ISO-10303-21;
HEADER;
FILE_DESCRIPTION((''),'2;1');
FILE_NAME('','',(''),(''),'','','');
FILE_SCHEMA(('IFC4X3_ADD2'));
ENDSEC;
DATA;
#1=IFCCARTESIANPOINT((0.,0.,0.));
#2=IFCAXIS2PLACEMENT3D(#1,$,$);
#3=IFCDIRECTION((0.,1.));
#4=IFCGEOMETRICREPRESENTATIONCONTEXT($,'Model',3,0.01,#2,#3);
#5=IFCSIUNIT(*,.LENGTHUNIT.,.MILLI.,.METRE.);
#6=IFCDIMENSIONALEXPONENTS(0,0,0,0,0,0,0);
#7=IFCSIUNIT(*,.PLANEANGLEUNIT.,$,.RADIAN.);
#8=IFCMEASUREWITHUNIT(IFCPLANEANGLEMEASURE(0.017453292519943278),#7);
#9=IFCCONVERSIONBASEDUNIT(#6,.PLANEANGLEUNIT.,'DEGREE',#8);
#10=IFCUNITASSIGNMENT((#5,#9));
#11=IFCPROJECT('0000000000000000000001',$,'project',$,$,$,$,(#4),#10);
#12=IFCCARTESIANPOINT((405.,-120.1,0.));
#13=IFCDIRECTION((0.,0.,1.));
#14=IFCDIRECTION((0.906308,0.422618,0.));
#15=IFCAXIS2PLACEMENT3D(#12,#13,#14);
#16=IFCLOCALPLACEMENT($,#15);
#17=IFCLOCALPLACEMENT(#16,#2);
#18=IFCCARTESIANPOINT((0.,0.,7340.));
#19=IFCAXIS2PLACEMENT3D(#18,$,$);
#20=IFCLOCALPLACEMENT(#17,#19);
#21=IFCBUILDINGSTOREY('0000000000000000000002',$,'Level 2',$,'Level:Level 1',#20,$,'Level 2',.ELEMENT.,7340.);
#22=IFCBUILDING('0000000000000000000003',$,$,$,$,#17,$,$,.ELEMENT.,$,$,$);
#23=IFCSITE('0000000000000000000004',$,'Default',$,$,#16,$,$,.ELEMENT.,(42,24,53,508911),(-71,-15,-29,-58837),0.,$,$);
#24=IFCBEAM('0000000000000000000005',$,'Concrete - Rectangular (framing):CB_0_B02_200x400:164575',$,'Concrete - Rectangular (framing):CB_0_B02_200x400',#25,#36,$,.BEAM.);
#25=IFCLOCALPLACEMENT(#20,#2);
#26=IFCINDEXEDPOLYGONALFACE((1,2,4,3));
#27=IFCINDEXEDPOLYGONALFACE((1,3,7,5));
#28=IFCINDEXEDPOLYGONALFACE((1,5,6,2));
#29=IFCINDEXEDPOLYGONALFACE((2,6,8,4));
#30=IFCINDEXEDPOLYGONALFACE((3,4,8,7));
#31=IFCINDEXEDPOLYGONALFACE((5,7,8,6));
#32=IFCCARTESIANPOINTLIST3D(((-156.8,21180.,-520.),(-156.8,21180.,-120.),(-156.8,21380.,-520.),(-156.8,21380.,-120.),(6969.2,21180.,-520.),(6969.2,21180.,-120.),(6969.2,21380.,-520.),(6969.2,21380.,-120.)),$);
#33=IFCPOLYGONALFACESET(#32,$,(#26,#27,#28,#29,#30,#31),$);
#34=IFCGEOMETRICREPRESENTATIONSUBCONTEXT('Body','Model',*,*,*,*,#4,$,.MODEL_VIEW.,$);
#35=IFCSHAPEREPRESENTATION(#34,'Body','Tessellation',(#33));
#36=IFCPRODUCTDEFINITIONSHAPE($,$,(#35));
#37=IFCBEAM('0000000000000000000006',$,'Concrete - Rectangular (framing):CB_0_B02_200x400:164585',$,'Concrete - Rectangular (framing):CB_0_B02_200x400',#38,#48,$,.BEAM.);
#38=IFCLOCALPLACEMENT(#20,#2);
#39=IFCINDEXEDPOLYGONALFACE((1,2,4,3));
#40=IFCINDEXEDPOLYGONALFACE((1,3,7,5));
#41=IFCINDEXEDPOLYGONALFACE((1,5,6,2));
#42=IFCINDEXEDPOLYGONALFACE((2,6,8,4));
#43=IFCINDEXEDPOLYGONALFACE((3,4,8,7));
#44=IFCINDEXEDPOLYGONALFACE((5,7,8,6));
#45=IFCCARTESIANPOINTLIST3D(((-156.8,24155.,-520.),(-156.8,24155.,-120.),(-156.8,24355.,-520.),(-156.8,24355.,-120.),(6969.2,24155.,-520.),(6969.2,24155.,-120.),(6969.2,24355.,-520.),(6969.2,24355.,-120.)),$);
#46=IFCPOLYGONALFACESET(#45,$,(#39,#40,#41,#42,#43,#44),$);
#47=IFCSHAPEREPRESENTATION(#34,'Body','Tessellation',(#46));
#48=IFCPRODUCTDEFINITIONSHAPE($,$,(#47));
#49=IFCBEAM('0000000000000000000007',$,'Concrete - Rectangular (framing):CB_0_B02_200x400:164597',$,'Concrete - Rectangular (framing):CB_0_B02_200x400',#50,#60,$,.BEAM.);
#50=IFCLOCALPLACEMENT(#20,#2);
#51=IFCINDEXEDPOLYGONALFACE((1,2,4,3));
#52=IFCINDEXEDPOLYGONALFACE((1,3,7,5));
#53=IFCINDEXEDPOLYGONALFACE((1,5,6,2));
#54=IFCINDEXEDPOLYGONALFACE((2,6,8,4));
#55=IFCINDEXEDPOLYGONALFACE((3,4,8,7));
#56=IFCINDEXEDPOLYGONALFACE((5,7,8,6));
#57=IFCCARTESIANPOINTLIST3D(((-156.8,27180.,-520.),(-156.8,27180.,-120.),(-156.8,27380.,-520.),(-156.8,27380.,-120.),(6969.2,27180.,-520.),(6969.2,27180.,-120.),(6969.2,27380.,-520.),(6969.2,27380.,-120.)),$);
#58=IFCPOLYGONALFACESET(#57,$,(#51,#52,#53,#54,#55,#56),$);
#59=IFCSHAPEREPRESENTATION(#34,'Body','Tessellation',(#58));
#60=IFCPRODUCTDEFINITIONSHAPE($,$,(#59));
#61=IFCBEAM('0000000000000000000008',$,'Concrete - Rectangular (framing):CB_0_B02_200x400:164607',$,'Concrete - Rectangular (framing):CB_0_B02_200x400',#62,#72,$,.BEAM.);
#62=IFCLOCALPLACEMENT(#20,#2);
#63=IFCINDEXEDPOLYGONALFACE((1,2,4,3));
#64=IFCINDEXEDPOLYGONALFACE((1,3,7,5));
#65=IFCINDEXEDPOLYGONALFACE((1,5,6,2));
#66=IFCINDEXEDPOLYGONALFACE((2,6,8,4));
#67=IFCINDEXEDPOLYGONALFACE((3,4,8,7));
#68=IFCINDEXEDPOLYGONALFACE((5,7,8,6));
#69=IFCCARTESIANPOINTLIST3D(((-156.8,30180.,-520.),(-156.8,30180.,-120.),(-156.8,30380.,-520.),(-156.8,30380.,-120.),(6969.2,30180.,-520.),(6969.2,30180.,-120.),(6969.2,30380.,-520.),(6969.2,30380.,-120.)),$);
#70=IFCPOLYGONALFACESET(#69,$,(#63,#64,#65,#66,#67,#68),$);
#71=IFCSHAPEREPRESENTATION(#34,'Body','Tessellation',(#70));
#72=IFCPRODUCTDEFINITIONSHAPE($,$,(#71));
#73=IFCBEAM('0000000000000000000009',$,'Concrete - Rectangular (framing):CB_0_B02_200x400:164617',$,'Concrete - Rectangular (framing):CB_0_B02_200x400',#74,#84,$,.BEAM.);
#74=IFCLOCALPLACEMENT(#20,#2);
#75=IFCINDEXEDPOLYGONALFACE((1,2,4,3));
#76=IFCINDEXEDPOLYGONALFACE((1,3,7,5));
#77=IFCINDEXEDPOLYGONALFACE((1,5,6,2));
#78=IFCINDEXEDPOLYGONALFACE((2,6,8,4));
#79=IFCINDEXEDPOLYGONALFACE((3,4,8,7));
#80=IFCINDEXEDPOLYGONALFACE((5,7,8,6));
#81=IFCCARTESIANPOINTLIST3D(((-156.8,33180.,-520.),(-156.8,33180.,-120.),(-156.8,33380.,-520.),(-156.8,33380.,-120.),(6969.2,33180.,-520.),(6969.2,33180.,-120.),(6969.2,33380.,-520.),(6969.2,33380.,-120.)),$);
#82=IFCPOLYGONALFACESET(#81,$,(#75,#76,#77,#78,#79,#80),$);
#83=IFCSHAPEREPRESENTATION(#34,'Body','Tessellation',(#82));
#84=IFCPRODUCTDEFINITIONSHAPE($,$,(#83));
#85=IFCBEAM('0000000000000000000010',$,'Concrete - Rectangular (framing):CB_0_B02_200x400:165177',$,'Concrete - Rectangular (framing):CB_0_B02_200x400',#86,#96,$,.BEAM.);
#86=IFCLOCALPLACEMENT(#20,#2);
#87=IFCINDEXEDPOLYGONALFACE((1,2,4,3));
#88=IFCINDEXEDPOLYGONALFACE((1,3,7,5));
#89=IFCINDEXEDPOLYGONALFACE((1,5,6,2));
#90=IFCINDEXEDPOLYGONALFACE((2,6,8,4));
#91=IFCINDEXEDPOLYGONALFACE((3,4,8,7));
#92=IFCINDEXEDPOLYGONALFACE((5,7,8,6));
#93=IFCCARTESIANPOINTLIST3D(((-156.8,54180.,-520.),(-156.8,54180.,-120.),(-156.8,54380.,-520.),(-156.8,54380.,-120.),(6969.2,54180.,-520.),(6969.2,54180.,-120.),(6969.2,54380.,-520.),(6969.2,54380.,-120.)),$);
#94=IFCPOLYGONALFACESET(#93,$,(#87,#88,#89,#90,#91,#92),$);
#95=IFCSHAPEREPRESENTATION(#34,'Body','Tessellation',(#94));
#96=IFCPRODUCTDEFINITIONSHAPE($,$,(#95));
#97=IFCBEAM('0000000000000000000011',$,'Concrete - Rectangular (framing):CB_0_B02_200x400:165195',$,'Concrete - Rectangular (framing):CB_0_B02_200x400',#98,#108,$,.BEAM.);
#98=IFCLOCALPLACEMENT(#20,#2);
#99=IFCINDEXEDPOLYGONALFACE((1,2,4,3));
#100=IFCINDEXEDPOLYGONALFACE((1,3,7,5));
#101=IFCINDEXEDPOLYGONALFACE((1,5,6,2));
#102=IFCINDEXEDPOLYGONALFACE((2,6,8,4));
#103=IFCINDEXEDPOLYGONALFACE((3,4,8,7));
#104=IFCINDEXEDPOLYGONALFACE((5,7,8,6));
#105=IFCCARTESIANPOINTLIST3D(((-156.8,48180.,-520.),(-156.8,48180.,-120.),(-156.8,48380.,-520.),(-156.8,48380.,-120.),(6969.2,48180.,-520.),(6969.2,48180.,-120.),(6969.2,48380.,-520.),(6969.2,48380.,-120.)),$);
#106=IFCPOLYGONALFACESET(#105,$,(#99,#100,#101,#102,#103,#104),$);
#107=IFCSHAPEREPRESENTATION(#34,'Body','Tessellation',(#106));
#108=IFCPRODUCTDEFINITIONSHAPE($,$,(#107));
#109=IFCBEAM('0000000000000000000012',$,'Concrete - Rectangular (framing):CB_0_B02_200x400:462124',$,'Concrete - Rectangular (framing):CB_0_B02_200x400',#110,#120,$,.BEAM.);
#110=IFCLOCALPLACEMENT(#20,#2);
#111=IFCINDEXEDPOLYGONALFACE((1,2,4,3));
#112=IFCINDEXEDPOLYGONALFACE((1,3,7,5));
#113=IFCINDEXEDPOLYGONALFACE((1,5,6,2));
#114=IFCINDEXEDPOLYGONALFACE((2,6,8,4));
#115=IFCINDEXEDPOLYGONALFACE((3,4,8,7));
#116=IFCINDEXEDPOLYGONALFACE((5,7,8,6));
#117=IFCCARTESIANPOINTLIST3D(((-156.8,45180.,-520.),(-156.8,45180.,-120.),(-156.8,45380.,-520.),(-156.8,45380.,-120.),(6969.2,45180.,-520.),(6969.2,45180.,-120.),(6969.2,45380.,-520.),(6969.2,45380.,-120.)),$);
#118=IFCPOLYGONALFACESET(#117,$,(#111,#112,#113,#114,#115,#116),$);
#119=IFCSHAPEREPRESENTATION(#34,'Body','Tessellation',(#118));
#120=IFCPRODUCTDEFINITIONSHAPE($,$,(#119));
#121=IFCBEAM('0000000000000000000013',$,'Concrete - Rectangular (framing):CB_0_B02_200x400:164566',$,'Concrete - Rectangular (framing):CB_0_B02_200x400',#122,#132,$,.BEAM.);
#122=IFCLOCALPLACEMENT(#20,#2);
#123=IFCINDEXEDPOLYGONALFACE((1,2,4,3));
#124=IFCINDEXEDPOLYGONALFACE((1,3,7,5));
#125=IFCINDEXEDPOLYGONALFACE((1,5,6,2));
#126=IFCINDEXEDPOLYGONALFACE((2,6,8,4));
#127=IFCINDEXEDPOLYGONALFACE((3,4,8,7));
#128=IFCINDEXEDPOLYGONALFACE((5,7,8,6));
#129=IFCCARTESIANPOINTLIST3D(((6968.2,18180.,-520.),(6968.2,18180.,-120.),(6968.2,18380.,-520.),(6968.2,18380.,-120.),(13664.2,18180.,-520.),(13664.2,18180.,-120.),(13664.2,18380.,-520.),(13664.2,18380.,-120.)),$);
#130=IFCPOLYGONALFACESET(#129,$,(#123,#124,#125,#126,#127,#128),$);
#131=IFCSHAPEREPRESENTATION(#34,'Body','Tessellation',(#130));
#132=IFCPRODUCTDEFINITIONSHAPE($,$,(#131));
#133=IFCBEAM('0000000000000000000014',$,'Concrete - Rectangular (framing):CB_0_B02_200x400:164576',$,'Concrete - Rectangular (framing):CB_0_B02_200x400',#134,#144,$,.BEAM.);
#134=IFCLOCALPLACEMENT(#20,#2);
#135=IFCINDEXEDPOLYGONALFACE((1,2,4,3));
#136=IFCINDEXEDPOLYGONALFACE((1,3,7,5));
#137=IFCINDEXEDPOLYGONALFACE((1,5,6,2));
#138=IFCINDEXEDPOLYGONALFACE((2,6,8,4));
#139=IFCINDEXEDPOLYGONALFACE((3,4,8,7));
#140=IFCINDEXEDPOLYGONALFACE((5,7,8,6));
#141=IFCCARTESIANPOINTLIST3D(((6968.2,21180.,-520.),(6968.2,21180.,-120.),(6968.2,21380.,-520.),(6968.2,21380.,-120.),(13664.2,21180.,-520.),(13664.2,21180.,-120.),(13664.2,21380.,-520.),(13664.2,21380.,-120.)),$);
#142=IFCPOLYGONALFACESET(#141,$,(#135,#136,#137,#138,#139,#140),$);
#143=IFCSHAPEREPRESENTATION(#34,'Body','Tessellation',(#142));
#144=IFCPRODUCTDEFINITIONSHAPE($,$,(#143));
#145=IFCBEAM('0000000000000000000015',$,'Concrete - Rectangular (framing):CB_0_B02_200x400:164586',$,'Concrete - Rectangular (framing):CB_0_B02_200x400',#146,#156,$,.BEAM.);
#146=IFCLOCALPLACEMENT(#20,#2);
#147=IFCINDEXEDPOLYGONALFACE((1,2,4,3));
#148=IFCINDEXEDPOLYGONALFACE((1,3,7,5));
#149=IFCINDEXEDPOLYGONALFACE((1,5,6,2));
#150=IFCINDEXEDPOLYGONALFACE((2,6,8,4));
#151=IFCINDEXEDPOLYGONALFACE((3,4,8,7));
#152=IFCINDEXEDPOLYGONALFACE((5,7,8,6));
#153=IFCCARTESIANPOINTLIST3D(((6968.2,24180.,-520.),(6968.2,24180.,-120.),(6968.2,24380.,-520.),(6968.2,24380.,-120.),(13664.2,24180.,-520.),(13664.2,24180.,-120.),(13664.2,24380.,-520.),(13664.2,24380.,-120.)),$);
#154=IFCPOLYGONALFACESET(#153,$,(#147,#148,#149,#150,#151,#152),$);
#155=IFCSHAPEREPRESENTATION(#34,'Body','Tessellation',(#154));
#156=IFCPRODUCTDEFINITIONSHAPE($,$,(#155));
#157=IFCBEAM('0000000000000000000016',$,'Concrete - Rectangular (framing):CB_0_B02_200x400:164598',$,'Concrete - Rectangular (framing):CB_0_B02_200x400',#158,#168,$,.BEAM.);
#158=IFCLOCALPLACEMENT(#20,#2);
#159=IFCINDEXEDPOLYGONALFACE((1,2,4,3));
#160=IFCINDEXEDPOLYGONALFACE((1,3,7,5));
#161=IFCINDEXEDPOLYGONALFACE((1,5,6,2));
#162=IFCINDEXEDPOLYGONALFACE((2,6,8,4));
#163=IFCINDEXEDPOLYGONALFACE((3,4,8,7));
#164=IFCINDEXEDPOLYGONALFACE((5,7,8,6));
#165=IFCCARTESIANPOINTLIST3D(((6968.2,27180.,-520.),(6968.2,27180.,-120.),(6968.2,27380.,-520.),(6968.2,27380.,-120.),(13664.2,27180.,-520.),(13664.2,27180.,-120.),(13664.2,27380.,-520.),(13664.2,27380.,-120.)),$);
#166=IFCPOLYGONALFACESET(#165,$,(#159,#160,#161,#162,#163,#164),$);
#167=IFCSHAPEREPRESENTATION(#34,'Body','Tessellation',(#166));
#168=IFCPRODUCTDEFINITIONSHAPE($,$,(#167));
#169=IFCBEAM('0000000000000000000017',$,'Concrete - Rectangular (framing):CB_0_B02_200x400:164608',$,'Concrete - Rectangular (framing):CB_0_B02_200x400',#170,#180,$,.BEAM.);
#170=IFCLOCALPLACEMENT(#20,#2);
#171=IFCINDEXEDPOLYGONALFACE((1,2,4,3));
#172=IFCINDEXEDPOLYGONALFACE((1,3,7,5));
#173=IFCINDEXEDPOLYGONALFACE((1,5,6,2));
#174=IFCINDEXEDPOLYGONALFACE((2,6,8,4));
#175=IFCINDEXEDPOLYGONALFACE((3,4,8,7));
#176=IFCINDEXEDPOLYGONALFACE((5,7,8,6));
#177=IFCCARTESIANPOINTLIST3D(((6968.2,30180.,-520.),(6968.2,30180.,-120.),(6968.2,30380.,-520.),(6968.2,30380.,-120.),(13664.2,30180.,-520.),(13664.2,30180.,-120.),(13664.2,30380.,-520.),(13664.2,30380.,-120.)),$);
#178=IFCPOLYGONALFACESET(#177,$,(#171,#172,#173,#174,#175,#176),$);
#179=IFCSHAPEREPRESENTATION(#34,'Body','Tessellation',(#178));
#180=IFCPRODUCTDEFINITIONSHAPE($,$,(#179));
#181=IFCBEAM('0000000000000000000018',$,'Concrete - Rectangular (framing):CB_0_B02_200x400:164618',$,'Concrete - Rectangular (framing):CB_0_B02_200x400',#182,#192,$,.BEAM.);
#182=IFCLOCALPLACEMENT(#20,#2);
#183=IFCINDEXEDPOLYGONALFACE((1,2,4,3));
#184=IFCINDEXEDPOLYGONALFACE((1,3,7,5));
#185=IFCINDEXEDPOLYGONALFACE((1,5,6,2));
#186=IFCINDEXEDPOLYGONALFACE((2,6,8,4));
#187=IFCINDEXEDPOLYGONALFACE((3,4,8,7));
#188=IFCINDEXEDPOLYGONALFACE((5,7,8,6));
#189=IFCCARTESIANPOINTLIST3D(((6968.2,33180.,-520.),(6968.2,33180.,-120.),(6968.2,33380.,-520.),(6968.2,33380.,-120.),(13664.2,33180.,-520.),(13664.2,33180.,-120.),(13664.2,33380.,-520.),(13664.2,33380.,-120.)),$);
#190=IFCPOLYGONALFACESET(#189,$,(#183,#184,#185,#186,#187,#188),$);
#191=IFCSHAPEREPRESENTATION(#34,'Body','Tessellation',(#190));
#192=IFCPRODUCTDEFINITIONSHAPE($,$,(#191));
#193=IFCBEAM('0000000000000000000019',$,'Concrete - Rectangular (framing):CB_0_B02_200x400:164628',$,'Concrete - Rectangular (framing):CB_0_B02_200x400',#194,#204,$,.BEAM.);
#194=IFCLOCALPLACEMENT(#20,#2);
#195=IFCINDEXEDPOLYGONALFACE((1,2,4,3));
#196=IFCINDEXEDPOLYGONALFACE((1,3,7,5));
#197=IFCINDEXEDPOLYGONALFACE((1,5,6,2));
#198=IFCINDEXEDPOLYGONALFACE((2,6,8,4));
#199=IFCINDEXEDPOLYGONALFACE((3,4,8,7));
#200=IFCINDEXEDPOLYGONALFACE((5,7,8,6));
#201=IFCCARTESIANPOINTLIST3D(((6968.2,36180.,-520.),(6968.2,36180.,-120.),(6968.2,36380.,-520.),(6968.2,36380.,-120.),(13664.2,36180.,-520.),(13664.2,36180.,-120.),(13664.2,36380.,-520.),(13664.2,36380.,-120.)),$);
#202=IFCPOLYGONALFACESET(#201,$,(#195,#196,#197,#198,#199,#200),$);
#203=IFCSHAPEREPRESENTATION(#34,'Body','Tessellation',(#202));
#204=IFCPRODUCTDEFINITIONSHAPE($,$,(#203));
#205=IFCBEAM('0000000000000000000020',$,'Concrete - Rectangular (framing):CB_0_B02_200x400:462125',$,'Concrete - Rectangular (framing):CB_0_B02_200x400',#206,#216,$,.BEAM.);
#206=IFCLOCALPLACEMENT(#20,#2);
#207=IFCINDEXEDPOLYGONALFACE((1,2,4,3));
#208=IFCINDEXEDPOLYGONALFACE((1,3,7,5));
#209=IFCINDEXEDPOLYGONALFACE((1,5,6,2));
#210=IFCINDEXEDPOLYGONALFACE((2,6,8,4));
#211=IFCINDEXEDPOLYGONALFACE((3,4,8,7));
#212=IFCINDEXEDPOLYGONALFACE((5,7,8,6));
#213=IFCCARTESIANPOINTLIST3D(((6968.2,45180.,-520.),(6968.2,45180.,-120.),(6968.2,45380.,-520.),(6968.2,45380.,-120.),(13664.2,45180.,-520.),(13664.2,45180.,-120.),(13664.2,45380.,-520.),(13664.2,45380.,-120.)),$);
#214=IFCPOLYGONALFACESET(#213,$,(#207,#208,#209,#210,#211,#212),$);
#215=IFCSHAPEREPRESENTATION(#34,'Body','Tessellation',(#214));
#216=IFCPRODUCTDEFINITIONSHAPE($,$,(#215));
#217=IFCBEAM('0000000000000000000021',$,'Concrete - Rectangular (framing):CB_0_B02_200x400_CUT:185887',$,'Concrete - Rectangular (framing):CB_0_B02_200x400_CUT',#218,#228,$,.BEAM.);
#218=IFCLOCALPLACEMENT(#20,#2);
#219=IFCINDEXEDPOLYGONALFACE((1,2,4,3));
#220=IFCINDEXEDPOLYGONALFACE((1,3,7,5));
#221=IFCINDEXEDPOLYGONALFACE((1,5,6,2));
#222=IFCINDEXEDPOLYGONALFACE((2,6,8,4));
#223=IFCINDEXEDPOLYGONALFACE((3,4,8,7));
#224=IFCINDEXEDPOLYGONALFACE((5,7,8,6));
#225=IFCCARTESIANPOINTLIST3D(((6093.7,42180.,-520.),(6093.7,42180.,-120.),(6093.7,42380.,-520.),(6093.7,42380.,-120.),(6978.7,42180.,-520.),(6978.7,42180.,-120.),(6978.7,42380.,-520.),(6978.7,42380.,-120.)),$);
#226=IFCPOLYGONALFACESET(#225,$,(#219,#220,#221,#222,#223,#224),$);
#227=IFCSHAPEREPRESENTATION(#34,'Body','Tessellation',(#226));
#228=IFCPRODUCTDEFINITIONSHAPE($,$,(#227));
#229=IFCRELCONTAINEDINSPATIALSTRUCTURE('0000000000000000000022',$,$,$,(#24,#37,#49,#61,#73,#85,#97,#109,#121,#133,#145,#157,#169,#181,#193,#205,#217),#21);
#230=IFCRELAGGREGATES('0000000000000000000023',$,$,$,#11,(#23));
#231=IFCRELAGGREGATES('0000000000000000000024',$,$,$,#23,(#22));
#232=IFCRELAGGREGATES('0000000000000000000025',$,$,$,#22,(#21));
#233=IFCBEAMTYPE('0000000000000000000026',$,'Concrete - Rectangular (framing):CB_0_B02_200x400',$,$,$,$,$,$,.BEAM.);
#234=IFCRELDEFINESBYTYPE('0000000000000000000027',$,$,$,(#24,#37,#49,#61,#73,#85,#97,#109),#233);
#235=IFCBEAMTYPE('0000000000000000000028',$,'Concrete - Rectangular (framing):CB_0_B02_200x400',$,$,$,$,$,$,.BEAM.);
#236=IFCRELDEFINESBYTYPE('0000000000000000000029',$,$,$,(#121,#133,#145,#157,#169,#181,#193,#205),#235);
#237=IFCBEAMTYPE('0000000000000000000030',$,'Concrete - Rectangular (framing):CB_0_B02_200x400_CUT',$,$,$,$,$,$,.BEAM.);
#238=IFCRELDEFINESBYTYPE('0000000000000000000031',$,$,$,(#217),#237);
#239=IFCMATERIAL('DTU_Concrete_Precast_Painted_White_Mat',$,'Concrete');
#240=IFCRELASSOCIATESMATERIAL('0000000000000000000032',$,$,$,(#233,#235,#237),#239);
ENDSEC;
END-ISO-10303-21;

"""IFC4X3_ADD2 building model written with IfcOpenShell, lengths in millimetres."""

from ifc_helpers import new_model, entity, si_unit, converted_unit, direction, frame, frame_2d, origin, origin_2d_with_axis, place, context, subcontext, project, spatial, rectangle, extrude, source, transform, mapped, material, material_profile, profile_set, type_object, type_shapes, element, save


model = new_model("IFC4X3_ADD2")

# Units and contexts
model_context = context("Model", 3, precision=0.01, world=origin(), true_north=direction((0.0, 1.0)))
body_context = subcontext(model_context, "Body", "Model", "MODEL_VIEW")
ifc_project = project(units=[si_unit("LENGTHUNIT", "METRE", prefix="MILLI"), converted_unit("PLANEANGLEUNIT", "DEGREE", entity("IfcPlaneAngleMeasure", 0.017453292519943278), si_unit("PLANEANGLEUNIT", "RADIAN"), dimensions=[0, 0, 0, 0, 0, 0, 0])], contexts=[model_context])

# Site, building, storey
site_placement = place(None, frame((405.0, -120.1, 0.0), z_axis=(0.0, 0.0, 1.0), x_axis=(0.906308, 0.422618, 0.0)))
site = spatial("IfcSite", under=ifc_project, at=site_placement, Name="Default", CompositionType="ELEMENT", RefLatitude=(42, 24, 53, 508911), RefLongitude=(-71, -15, -29, -58837), RefElevation=0.0)
building_placement = place(site_placement, origin())
building = spatial("IfcBuilding", under=site, at=building_placement, CompositionType="ELEMENT")
storey_placement = place(building_placement, frame((0.0, 0.0, 7340.0)))
storey = spatial("IfcBuildingStorey", under=building, at=storey_placement, Name="Level 2", ObjectType="Level:Level 1", LongName="Level 2", CompositionType="ELEMENT", Elevation=7340.0)

# Beams
ifc_material_1 = material(Name="DTU_Concrete_Precast_Painted_White_Mat", Category="Concrete")
ifc_material_profile_1 = material_profile(ifc_material_1, rectangle(XDim=7035.5, YDim=200.0, at=frame_2d((0.0, 0.0), x_axis=(1.0, 0.0))), Name="CB_0_B02_200x400")
ifc_profile_set_1 = profile_set([ifc_material_profile_1], Name="CB_0_B02_200x400")
beam_type_1 = type_object("IfcBeamType", Name="Concrete - Rectangular (framing):CB_0_B02_200x400", PredefinedType="BEAM", material=ifc_profile_set_1)
shared_shape_1 = source(origin(), body_context, "Body", "SweptSolid", [
    extrude(rectangle(XDim=7126.0, YDim=200.0, at=origin_2d_with_axis()), frame((0.0, 0.0, -200.0), z_axis=(0.0, 0.0, 1.0), x_axis=(-1.0, 0.0, 0.0)), (0.0, 0.0, 1.0), 400.0),
])
type_shapes(beam_type_1, [shared_shape_1])
for number, where, z_axis, x_axis, name in (
    (1, (3406.2, 21280.0, -320.0), (0.0, 0.0, 1.0), (-1.0, 0.0, 0.0), "Concrete - Rectangular (framing):CB_0_B02_200x400:164575"),
    (2, (3406.2, 24255.0, -320.0), (0.0, 0.0, 1.0), (-1.0, 0.0, 0.0), "Concrete - Rectangular (framing):CB_0_B02_200x400:164585"),
    (3, (3406.2, 27280.0, -320.0), (0.0, 0.0, 1.0), (-1.0, 0.0, 0.0), "Concrete - Rectangular (framing):CB_0_B02_200x400:164597"),
    (4, (3406.2, 30280.0, -320.0), (0.0, 0.0, 1.0), (-1.0, 0.0, 0.0), "Concrete - Rectangular (framing):CB_0_B02_200x400:164607"),
    (5, (3406.2, 33280.0, -320.0), (0.0, 0.0, 1.0), (-1.0, 0.0, 0.0), "Concrete - Rectangular (framing):CB_0_B02_200x400:164617"),
    (6, (3406.2, 54280.0, -320.0), (0.0, 0.0, 1.0), (-1.0, 0.0, 0.0), "Concrete - Rectangular (framing):CB_0_B02_200x400:165177"),
    (7, (3406.2, 48280.0, -320.0), (0.0, 0.0, 1.0), (-1.0, 0.0, 0.0), "Concrete - Rectangular (framing):CB_0_B02_200x400:165195"),
    (8, (3406.2, 45280.0, -320.0), (0.0, 0.0, 1.0), (-1.0, 0.0, 0.0), "Concrete - Rectangular (framing):CB_0_B02_200x400:462124"),
):
    element("IfcBeam", number, at=place(storey_placement, frame(where, z_axis=z_axis, x_axis=x_axis)), inside=storey, type_object=beam_type_1, Name=name, ObjectType="Concrete - Rectangular (framing):CB_0_B02_200x400", PredefinedType="BEAM", context=body_context, shape_type="MappedRepresentation", body=[
        mapped(shared_shape_1, transform((0.0, 0.0, 0.0), scale=1.0)),
    ])
beam_type_2 = type_object("IfcBeamType", Name="Concrete - Rectangular (framing):CB_0_B02_200x400", PredefinedType="BEAM", material=ifc_profile_set_1)
shared_shape_2 = source(origin(), body_context, "Body", "SweptSolid", [
    extrude(rectangle(XDim=6696.0, YDim=200.0, at=frame_2d((0.0, 0.0), x_axis=(1.0, 0.0))), frame((0.0, 0.0, -200.0), z_axis=(0.0, 0.0, 1.0), x_axis=(-1.0, 0.0, 0.0)), (0.0, 0.0, 1.0), 400.0),
])
type_shapes(beam_type_2, [shared_shape_2])
for number, where, name in (
    (9, (10316.2, 18280.0, -320.0), "Concrete - Rectangular (framing):CB_0_B02_200x400:164566"),
    (10, (10316.2, 21280.0, -320.0), "Concrete - Rectangular (framing):CB_0_B02_200x400:164576"),
    (11, (10316.2, 24280.0, -320.0), "Concrete - Rectangular (framing):CB_0_B02_200x400:164586"),
    (12, (10316.2, 27280.0, -320.0), "Concrete - Rectangular (framing):CB_0_B02_200x400:164598"),
    (13, (10316.2, 30280.0, -320.0), "Concrete - Rectangular (framing):CB_0_B02_200x400:164608"),
    (14, (10316.2, 33280.0, -320.0), "Concrete - Rectangular (framing):CB_0_B02_200x400:164618"),
    (15, (10316.2, 36280.0, -320.0), "Concrete - Rectangular (framing):CB_0_B02_200x400:164628"),
    (16, (10316.2, 45280.0, -320.0), "Concrete - Rectangular (framing):CB_0_B02_200x400:462125"),
):
    element("IfcBeam", number, at=place(storey_placement, frame(where)), inside=storey, type_object=beam_type_2, Name=name, ObjectType="Concrete - Rectangular (framing):CB_0_B02_200x400", PredefinedType="BEAM", context=body_context, shape_type="MappedRepresentation", body=[
        mapped(shared_shape_2, transform((0.0, 0.0, 0.0), scale=1.0)),
    ])
ifc_material_profile_2 = material_profile(ifc_material_1, rectangle(XDim=885.0, YDim=200.0, at=origin_2d_with_axis()), Name="CB_0_B02_200x400_CUT")
ifc_profile_set_2 = profile_set([ifc_material_profile_2], Name="CB_0_B02_200x400_CUT")
beam_type_3 = type_object("IfcBeamType", Name="Concrete - Rectangular (framing):CB_0_B02_200x400_CUT", PredefinedType="BEAM", material=ifc_profile_set_2)
shared_shape_3 = source(origin(), body_context, "Body", "SweptSolid", [
    extrude(rectangle(XDim=885.0, YDim=200.0, at=origin_2d_with_axis()), frame((0.0, 0.0, -200.0), z_axis=(0.0, 0.0, 1.0), x_axis=(-1.0, 0.0, 0.0)), (0.0, 0.0, 1.0), 400.0),
])
type_shapes(beam_type_3, [shared_shape_3])
for number, where, z_axis, x_axis, name in (
    (17, (6536.2, 42280.0, -320.0), (0.0, 0.0, 1.0), (-1.0, 0.0, 0.0), "Concrete - Rectangular (framing):CB_0_B02_200x400_CUT:185887"),
):
    element("IfcBeam", number, at=place(storey_placement, frame(where, z_axis=z_axis, x_axis=x_axis)), inside=storey, type_object=beam_type_3, Name=name, ObjectType="Concrete - Rectangular (framing):CB_0_B02_200x400_CUT", PredefinedType="BEAM", context=body_context, shape_type="MappedRepresentation", body=[
        mapped(shared_shape_3, transform((0.0, 0.0, 0.0), scale=1.0)),
    ])

save(model, "model.ifc")
